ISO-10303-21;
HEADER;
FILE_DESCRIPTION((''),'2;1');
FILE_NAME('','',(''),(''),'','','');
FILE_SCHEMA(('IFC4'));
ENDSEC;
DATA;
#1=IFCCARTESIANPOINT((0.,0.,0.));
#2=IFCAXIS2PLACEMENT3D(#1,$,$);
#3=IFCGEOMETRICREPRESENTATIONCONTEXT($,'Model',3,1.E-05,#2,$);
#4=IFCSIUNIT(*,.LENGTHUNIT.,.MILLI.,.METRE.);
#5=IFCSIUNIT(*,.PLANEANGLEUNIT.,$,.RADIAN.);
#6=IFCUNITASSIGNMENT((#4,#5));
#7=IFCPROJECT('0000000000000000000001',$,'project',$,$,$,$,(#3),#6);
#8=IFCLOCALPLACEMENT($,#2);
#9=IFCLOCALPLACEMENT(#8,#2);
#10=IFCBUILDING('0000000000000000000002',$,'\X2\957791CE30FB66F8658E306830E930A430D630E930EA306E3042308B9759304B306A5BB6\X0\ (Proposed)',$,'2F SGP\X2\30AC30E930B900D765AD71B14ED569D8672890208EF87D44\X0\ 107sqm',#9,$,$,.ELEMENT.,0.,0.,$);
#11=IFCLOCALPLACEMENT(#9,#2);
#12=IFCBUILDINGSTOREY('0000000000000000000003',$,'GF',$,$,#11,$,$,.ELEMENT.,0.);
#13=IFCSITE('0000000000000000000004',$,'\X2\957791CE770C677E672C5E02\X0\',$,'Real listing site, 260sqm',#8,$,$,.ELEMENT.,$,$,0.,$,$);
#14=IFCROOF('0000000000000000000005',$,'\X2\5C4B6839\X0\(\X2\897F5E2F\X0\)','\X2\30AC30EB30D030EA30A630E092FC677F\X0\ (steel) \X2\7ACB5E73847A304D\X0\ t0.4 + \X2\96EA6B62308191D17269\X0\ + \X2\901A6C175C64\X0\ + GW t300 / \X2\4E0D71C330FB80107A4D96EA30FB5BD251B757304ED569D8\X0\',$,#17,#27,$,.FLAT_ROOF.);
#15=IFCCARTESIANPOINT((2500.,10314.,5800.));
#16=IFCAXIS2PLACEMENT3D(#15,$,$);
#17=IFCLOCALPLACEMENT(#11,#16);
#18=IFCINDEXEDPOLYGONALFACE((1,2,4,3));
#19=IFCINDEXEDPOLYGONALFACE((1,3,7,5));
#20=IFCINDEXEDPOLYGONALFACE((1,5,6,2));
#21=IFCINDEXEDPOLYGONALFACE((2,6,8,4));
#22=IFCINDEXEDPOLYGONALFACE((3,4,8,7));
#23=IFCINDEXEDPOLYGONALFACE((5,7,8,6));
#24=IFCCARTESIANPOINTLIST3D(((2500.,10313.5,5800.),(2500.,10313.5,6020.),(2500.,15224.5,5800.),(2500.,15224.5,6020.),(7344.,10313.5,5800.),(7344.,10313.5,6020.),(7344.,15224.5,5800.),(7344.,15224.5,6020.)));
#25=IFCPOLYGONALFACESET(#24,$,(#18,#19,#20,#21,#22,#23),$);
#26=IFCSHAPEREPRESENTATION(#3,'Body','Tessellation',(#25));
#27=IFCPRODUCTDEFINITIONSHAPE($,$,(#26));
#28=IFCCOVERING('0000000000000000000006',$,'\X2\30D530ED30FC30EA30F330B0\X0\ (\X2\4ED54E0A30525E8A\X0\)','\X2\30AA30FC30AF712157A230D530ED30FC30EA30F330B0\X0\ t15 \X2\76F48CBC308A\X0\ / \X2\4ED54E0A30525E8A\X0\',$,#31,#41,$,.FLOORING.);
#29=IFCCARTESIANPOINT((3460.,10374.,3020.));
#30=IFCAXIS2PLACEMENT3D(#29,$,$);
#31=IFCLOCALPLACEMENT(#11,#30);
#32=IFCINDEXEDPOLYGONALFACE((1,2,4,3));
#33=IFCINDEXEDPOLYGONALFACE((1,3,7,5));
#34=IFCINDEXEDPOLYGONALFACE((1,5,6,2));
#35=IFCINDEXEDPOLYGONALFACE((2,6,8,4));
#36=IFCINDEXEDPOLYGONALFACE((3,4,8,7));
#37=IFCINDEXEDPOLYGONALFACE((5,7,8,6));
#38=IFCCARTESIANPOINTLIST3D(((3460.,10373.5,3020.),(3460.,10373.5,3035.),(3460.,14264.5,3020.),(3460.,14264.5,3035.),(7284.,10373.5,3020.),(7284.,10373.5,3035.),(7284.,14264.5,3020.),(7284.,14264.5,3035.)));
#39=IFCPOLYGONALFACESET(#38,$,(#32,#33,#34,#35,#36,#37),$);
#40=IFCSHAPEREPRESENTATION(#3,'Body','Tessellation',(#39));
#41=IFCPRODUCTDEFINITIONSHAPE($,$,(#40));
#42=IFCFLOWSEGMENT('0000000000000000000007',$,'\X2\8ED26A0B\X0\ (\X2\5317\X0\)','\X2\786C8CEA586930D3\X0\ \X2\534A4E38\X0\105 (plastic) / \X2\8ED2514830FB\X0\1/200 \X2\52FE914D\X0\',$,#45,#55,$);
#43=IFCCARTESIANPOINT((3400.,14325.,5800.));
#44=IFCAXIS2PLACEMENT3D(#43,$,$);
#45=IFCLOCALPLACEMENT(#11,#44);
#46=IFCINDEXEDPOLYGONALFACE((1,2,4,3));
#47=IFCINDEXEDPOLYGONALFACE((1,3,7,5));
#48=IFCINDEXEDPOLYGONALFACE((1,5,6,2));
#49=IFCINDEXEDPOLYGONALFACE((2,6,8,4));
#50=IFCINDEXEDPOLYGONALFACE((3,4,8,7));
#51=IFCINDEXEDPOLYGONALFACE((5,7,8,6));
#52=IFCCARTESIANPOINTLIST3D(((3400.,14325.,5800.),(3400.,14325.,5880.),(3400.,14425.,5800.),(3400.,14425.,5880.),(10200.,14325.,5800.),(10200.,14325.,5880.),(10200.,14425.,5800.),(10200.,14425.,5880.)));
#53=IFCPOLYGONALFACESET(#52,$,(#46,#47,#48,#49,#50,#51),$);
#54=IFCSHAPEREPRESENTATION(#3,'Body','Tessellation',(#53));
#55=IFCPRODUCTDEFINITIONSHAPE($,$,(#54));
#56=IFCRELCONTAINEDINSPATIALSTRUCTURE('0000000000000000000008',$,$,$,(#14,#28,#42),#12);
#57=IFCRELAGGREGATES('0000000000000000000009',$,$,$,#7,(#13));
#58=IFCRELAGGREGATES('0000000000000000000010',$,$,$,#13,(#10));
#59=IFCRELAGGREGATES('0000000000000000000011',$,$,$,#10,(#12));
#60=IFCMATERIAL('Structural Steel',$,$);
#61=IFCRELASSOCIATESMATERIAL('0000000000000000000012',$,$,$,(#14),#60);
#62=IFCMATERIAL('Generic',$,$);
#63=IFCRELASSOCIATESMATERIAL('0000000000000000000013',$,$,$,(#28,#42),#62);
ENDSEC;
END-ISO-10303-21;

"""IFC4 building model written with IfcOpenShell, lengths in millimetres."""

from ifc_helpers import new_model, si_unit, frame, frame_2d, origin, place, context, project, spatial, rectangle, extrude, material, element, save


model = new_model("IFC4")

# Units and contexts
model_context = context("Model", 3, precision=1e-05, world=origin())
ifc_project = project(units=[si_unit("LENGTHUNIT", "METRE", prefix="MILLI"), si_unit("PLANEANGLEUNIT", "RADIAN")], contexts=[model_context])

# Site, building, storey
site_placement = place(None, origin())
site = spatial("IfcSite", under=ifc_project, at=site_placement, Name="長野県松本市", ObjectType="Real listing site, 260sqm", CompositionType="ELEMENT", RefElevation=0.0)
building_placement = place(site_placement, origin())
building = spatial("IfcBuilding", under=site, at=building_placement, Name="長野・書斎とライブラリのある静かな家 (Proposed)", ObjectType="2F SGPガラス×断熱仕様木造軸組 107sqm", CompositionType="ELEMENT", ElevationOfRefHeight=0.0, ElevationOfTerrain=0.0)
storey_placement = place(building_placement, origin())
storey = spatial("IfcBuildingStorey", under=building, at=storey_placement, Name="GF", CompositionType="ELEMENT", Elevation=0.0)

# Roof
ifc_material_1 = material(Name="Structural Steel")
for number, where, name in (
    (1, (2500.0, 10314.0, 5800.0), "屋根(西帯)"),
):
    element("IfcRoof", number, at=place(storey_placement, frame(where)), inside=storey, material=ifc_material_1, Name=name, Description="ガルバリウム鋼板 (steel) 立平葺き t0.4 + 雪止め金物 + 通気層 + GW t300 / 不燃・耐積雪・寒冷地仕様", PredefinedType="FLAT_ROOF", context=model_context, shape_type="SweptSolid", body=[
        extrude(rectangle(XDim=4844.0, YDim=4911.0, at=frame_2d((2422.0, 2455.0))), frame((2500.0, 10314.0, 5800.0)), (0.0, 0.0, 1.0), 220.0),
    ])

# Covering
ifc_material_2 = material(Name="Generic")
covering_placement = place(storey_placement, frame((3460.0, 10374.0, 3020.0)))
element("IfcCovering", 2, at=covering_placement, inside=storey, material=ifc_material_2, Name="フローリング (仕上げ床)", Description="オーク無垢フローリング t15 直貼り / 仕上げ床", PredefinedType="FLOORING", context=model_context, shape_type="SweptSolid", body=[
    extrude(rectangle(XDim=3824.0, YDim=3891.0, at=frame_2d((1912.0, 1945.0))), frame((3460.0, 10374.0, 3020.0)), (0.0, 0.0, 1.0), 15.0),
])

# Flow segment
flow_segment_placement = place(storey_placement, frame((3400.0, 14325.0, 5800.0)))
element("IfcFlowSegment", 3, at=flow_segment_placement, inside=storey, material=ifc_material_2, Name="軒樋 (北)", Description="硬質塩ビ 半丸105 (plastic) / 軒先・1/200 勾配", context=model_context, shape_type="SweptSolid", body=[
    extrude(rectangle(XDim=6800.0, YDim=100.0, at=frame_2d((3400.0, 50.0))), frame((3400.0, 14325.0, 5800.0)), (0.0, 0.0, 1.0), 80.0),
])

save(model, "model.ifc")
